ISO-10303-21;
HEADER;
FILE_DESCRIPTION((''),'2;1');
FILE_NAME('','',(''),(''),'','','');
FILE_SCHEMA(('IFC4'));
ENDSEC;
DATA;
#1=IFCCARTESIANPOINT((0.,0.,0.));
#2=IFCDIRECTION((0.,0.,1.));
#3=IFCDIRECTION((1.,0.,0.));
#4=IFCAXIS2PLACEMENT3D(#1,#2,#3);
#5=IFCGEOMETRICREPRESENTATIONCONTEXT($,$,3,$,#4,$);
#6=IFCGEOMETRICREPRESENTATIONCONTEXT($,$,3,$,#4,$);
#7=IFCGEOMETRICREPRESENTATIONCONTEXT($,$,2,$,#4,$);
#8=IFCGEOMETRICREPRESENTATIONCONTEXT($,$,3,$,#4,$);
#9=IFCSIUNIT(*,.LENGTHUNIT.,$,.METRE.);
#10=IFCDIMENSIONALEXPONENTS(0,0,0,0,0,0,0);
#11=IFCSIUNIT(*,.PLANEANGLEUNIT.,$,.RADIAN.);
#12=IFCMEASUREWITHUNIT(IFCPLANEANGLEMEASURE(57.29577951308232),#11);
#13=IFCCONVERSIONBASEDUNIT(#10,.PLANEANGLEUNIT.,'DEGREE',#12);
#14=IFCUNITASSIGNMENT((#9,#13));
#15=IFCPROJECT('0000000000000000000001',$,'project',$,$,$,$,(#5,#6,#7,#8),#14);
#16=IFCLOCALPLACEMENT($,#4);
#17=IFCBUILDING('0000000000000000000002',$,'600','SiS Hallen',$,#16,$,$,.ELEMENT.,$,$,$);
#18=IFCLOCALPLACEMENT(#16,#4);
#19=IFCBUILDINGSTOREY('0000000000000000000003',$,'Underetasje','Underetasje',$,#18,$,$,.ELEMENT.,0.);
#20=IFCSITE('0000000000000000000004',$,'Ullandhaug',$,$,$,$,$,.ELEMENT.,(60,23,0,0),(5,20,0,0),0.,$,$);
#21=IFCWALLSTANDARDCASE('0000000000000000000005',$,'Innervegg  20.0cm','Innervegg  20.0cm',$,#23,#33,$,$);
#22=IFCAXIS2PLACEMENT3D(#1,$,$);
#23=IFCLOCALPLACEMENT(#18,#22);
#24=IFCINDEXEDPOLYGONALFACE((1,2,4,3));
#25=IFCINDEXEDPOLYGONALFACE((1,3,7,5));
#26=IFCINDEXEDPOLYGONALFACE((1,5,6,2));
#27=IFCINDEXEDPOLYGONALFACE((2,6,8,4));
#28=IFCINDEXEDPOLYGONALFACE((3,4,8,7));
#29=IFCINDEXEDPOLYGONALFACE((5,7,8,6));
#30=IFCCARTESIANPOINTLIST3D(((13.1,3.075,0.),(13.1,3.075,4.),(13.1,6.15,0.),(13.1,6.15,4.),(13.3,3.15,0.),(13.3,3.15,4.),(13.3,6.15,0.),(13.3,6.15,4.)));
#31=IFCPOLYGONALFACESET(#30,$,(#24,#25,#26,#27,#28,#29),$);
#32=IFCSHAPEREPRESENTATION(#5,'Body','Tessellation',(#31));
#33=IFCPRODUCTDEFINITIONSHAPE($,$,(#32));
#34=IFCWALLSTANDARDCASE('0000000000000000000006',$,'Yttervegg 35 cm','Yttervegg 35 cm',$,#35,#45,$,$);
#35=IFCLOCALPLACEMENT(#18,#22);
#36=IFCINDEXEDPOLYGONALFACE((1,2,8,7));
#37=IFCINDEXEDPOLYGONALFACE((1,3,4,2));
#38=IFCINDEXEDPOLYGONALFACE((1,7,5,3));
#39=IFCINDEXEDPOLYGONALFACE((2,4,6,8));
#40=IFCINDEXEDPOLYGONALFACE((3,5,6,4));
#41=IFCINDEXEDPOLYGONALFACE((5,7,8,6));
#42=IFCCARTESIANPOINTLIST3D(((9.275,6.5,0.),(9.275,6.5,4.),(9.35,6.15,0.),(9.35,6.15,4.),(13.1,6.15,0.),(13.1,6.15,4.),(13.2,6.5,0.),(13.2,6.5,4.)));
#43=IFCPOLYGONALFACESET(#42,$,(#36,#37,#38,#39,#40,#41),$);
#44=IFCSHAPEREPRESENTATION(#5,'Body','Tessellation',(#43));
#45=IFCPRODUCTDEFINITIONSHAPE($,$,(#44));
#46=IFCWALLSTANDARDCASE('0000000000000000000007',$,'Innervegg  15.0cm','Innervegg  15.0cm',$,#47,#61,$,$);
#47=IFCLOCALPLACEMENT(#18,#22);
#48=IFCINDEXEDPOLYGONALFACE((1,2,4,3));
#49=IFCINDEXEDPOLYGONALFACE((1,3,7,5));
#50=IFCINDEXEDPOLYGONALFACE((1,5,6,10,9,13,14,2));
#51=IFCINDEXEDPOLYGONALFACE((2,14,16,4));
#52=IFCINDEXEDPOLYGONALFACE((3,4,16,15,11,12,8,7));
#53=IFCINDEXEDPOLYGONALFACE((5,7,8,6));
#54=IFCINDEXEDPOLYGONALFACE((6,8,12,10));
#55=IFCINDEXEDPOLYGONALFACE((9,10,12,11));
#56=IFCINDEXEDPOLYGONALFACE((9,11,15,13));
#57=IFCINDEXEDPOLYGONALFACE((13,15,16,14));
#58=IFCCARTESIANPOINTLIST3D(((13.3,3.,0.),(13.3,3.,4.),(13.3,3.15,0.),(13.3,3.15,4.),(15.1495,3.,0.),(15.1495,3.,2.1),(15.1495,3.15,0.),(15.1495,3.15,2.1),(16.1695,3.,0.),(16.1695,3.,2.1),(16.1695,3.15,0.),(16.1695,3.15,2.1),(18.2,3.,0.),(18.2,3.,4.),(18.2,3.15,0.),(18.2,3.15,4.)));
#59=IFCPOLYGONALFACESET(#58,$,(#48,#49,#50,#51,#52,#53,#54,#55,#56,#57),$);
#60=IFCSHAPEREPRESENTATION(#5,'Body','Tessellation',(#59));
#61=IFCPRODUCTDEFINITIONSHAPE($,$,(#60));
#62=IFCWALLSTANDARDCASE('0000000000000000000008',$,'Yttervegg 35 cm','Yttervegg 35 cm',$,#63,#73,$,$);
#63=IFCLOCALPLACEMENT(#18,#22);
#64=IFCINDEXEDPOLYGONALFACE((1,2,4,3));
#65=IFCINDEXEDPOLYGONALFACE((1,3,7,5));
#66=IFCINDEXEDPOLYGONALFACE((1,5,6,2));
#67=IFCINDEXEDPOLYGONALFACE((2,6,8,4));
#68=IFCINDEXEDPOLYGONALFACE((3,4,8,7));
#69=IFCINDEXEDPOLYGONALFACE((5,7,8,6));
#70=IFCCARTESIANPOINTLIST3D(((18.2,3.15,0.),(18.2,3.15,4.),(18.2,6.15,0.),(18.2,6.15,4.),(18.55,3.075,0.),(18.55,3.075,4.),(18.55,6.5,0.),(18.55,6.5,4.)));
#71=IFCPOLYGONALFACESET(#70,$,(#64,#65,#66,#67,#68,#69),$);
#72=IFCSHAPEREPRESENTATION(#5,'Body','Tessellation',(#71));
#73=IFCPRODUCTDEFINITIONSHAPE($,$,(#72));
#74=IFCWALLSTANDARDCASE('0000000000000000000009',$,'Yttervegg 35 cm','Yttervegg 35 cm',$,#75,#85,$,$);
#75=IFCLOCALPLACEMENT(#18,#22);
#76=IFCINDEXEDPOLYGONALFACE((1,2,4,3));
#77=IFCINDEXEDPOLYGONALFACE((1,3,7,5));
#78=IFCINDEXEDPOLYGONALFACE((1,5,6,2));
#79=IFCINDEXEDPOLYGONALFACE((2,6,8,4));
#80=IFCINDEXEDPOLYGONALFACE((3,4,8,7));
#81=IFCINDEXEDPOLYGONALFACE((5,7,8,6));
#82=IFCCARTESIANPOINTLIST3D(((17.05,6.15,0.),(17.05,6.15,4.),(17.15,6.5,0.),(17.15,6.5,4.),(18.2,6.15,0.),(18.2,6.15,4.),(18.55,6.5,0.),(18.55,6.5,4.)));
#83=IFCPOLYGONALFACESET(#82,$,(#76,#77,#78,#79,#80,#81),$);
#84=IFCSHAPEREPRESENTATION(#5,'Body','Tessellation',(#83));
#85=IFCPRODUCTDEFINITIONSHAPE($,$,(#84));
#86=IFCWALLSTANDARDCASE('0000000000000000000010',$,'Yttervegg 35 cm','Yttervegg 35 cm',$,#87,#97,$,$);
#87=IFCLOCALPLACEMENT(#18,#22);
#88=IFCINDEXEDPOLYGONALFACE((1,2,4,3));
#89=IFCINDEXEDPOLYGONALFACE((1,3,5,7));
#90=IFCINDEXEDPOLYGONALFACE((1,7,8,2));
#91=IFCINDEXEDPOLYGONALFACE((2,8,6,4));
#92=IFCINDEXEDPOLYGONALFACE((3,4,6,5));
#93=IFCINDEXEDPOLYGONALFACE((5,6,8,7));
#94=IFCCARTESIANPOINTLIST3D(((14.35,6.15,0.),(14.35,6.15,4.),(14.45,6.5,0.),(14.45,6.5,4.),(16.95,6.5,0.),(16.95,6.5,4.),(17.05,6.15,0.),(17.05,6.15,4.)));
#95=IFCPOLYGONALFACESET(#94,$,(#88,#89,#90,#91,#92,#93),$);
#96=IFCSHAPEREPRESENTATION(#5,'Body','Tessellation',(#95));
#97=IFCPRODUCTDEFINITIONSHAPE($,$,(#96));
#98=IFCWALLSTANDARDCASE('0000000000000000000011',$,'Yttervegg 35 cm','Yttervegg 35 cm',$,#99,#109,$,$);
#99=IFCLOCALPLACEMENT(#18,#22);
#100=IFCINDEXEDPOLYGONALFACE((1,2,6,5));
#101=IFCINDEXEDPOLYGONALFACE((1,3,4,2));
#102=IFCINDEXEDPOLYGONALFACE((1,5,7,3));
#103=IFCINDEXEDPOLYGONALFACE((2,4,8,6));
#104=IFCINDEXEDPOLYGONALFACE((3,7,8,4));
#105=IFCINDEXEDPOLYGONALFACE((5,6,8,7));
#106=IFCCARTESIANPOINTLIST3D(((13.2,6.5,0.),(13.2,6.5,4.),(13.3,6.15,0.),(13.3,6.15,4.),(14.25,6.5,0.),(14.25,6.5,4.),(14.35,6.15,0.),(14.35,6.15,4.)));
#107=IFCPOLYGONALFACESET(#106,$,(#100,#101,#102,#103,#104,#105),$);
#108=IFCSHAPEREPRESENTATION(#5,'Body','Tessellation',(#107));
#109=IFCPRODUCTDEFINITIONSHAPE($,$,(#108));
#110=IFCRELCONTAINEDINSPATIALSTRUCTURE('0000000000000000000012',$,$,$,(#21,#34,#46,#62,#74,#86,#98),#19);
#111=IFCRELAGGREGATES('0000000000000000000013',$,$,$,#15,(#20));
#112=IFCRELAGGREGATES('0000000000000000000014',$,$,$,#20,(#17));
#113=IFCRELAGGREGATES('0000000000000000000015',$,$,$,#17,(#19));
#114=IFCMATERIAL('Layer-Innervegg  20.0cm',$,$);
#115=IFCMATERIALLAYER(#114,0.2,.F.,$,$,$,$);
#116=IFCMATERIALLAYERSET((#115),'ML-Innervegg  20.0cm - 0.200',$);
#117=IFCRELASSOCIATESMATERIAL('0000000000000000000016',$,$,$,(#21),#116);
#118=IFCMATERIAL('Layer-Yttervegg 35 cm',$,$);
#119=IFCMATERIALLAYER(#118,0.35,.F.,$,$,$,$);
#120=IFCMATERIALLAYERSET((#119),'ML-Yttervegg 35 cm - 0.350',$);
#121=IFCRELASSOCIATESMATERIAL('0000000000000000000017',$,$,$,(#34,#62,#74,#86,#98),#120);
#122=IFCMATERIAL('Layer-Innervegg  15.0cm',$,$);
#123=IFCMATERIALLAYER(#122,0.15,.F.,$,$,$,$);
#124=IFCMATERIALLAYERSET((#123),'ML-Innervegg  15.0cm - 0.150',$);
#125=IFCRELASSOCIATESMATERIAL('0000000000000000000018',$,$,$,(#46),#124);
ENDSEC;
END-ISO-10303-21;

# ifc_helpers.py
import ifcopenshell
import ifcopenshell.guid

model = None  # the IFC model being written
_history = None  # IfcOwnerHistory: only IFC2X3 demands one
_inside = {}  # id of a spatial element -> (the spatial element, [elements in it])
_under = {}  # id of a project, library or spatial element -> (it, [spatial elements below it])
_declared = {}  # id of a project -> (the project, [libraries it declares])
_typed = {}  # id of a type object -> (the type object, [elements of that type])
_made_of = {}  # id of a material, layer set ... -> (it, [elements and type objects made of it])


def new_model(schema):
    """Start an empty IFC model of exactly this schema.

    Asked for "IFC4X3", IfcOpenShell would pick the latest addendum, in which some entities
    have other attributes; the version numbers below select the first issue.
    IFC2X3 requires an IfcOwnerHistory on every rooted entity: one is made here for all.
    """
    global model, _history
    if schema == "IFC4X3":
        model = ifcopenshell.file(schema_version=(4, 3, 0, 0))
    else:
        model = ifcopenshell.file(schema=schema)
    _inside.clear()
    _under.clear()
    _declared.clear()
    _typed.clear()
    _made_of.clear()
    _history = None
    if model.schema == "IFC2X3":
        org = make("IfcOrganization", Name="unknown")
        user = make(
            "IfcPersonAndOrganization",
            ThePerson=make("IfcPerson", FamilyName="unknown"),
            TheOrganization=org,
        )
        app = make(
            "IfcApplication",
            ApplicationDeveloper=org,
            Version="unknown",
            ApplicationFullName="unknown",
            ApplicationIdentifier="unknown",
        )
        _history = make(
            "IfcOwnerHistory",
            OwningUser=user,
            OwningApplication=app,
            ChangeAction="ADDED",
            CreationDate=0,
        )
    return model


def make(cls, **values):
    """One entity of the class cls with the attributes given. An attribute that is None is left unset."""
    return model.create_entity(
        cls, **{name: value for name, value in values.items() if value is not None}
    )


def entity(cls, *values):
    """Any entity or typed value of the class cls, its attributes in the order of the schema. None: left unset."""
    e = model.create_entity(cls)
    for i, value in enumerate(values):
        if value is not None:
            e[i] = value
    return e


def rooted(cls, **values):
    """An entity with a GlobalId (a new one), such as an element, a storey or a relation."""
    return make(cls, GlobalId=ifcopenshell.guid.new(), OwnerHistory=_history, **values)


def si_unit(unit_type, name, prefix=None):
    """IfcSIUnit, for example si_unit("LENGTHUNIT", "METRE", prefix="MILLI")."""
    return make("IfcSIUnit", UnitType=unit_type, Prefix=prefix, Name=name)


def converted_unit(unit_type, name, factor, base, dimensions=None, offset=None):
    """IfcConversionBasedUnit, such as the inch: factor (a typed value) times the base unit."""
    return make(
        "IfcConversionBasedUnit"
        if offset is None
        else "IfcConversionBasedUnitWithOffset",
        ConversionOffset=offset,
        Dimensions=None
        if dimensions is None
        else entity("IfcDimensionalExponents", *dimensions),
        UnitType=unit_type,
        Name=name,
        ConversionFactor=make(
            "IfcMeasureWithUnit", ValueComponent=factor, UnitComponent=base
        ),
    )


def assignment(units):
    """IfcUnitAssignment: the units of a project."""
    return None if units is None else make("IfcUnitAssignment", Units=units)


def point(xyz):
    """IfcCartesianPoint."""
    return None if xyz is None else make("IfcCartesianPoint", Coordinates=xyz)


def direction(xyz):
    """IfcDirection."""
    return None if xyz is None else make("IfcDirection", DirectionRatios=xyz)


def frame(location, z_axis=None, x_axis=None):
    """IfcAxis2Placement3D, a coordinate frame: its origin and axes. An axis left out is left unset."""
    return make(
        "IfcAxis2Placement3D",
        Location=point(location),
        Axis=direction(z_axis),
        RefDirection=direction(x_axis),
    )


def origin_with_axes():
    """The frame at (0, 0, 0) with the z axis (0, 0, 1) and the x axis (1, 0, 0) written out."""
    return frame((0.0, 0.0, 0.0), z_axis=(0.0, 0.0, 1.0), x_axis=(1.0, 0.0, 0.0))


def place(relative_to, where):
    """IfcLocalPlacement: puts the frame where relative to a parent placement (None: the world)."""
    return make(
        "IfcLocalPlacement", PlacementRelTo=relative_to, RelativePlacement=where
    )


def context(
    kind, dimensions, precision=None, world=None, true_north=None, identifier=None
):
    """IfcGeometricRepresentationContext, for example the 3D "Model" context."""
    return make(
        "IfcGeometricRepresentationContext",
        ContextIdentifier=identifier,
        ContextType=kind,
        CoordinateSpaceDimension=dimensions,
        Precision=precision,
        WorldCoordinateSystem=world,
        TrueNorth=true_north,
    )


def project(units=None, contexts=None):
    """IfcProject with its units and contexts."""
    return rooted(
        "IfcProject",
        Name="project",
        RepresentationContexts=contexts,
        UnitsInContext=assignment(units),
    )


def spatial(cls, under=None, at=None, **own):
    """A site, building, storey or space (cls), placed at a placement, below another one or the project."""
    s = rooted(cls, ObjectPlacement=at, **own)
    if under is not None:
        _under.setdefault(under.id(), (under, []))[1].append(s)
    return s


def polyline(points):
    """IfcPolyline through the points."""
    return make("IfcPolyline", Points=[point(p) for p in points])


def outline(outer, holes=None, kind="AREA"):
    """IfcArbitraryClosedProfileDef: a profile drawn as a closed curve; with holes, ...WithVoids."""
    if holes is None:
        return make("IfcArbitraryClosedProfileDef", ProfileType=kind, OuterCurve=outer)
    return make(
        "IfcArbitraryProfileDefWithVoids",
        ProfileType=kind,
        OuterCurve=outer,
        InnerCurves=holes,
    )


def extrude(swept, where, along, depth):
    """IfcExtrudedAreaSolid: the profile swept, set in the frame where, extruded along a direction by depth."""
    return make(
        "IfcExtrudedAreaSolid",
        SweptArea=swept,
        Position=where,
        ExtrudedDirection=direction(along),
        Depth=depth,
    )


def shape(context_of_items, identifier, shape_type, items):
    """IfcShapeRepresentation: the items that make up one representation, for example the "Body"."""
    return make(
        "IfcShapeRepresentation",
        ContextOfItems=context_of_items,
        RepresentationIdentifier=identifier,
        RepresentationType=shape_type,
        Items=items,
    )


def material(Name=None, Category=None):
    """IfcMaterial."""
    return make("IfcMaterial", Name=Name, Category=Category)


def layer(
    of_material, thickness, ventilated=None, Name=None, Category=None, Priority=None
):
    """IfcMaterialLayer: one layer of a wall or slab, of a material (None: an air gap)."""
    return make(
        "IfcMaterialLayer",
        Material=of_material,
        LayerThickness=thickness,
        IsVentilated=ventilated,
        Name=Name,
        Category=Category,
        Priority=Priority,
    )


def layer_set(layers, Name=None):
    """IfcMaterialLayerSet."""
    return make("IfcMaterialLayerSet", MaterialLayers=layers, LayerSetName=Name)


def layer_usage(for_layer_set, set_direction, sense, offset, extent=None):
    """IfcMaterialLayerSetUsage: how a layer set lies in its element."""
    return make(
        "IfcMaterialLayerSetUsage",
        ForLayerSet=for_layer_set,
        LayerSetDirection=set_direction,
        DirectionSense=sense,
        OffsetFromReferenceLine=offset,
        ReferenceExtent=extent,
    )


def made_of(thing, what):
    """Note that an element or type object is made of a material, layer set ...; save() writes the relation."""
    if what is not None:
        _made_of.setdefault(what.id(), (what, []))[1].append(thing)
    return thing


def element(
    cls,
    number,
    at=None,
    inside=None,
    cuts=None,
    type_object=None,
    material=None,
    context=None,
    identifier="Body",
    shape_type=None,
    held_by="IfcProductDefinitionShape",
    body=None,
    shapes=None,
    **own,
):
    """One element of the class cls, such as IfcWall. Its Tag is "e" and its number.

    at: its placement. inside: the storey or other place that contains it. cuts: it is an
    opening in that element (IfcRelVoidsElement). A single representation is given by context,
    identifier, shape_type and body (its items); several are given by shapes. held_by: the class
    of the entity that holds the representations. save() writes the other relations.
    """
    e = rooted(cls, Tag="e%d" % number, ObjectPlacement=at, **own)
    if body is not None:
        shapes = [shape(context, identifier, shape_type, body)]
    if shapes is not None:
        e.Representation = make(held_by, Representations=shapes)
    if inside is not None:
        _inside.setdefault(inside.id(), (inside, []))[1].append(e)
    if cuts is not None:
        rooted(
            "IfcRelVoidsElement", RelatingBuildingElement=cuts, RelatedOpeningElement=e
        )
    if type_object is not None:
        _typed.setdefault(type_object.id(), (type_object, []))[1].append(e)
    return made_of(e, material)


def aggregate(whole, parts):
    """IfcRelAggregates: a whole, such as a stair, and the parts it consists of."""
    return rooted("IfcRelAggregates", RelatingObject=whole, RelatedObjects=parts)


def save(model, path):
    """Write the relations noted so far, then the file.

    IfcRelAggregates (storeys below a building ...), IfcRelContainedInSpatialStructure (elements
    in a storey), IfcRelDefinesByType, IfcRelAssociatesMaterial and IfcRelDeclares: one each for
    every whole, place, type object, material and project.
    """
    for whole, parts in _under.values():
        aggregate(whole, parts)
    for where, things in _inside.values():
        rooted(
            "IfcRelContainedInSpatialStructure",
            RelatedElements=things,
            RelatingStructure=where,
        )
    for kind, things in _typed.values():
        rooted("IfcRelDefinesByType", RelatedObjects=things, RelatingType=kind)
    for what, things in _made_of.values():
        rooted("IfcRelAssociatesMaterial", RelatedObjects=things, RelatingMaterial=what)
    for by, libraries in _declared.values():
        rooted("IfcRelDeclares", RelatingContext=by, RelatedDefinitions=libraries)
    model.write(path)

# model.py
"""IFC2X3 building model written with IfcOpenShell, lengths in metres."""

from ifc_helpers import new_model, entity, si_unit, converted_unit, frame, origin_with_axes, place, context, project, spatial, polyline, outline, extrude, material, layer, layer_set, layer_usage, element, save


model = new_model("IFC2X3")

# Units and contexts
context_of_model_1 = context(None, 3, world=origin_with_axes())
context_of_model_2 = context(None, 3, world=origin_with_axes())
context_of_model_3 = context(None, 2, world=origin_with_axes())
context_of_model_4 = context(None, 3, world=origin_with_axes())
ifc_project = project(units=[si_unit("LENGTHUNIT", "METRE"), converted_unit("PLANEANGLEUNIT", "DEGREE", entity("IfcPlaneAngleMeasure", 57.29577951308232), si_unit("PLANEANGLEUNIT", "RADIAN"), dimensions=[0, 0, 0, 0, 0, 0, 0])], contexts=[context_of_model_1, context_of_model_2, context_of_model_3, context_of_model_4])

# Site, building, storey
site = spatial("IfcSite", under=ifc_project, Name="Ullandhaug", CompositionType="ELEMENT", RefLatitude=(60, 23, 0, 0), RefLongitude=(5, 20, 0, 0), RefElevation=0.0)
building_placement = place(None, origin_with_axes())
building = spatial("IfcBuilding", under=site, at=building_placement, Name="600", Description="SiS Hallen", CompositionType="ELEMENT")
storey_placement = place(building_placement, origin_with_axes())
storey = spatial("IfcBuildingStorey", under=building, at=storey_placement, Name="Underetasje", Description="Underetasje", CompositionType="ELEMENT", Elevation=0.0)

# Shared definitions
ifc_material_1 = material(Name="Layer-Innervegg  15.0cm")
ifc_layer_1 = layer(ifc_material_1, 0.15, ventilated=False)
ifc_layer_set_1 = layer_set([ifc_layer_1], Name="ML-Innervegg  15.0cm - 0.150")
ifc_layer_usage_1 = layer_usage(ifc_layer_set_1, "AXIS2", "POSITIVE", 0.0)

# Shared definitions
ifc_material_2 = material(Name="Layer-Yttervegg 35 cm")
ifc_layer_2 = layer(ifc_material_2, 0.35, ventilated=False)
ifc_layer_set_2 = layer_set([ifc_layer_2], Name="ML-Yttervegg 35 cm - 0.350")
ifc_layer_usage_2 = layer_usage(ifc_layer_set_2, "AXIS2", "POSITIVE", 0.0)

# Walls
ifc_material_3 = material(Name="Layer-Innervegg  20.0cm")
ifc_layer_3 = layer(ifc_material_3, 0.2, ventilated=False)
ifc_layer_set_3 = layer_set([ifc_layer_3], Name="ML-Innervegg  20.0cm - 0.200")
ifc_layer_usage_3 = layer_usage(ifc_layer_set_3, "AXIS2", "POSITIVE", 0.0)
wall_1_placement = place(storey_placement, frame((13.3, 3.15, 0.0), z_axis=(0.0, 0.0, 1.0), x_axis=(0.0, 1.0, 0.0)))
element("IfcWallStandardCase", 1, at=wall_1_placement, inside=storey, material=ifc_layer_usage_3, Name="Innervegg  20.0cm", Description="Innervegg  20.0cm", context=context_of_model_1, shape_type="SweptSolid", body=[
    extrude(outline(polyline([(0.0, 0.0), (3.0, 0.0), (3.0, 0.2), (-0.075, 0.2), (0.0, 0.0)])), frame((0.0, 0.0, 0.0), z_axis=(0.0, 0.0, 1.0), x_axis=(1.0, 0.0, 0.0)), (0.0, 0.0, 1.0), 4.0),
])
wall_2_placement = place(storey_placement, frame((13.2, 6.5, 0.0), z_axis=(0.0, 0.0, 1.0), x_axis=(-1.0, 0.0, 0.0)))
element("IfcWallStandardCase", 2, at=wall_2_placement, inside=storey, material=ifc_layer_usage_2, Name="Yttervegg 35 cm", Description="Yttervegg 35 cm", context=context_of_model_1, shape_type="SweptSolid", body=[
    extrude(outline(polyline([(0.0, 0.0), (3.925, 0.0), (3.85, 0.35), (0.1, 0.35), (0.0, 0.0)])), frame((0.0, 0.0, 0.0), z_axis=(0.0, 0.0, 1.0), x_axis=(1.0, 0.0, 0.0)), (0.0, 0.0, 1.0), 4.0),
])

# Wall, opening
wall_3_placement = place(storey_placement, frame((18.2, 3.15, 0.0), z_axis=(0.0, 0.0, 1.0), x_axis=(-1.0, 0.0, 0.0)))
wall_3 = element("IfcWallStandardCase", 3, at=wall_3_placement, inside=storey, material=ifc_layer_usage_1, Name="Innervegg  15.0cm", Description="Innervegg  15.0cm", context=context_of_model_1, shape_type="SweptSolid", body=[
    extrude(outline(polyline([(0.0, 0.0), (4.9, 0.0), (4.9, 0.15), (0.0, 0.15), (0.0, 0.0)])), frame((0.0, 0.0, 0.0), z_axis=(0.0, 0.0, 1.0), x_axis=(1.0, 0.0, 0.0)), (0.0, 0.0, 1.0), 4.0),
])
opening_1_placement = place(wall_3_placement, frame((2.0305, 0.15, 0.0), z_axis=(0.0, 0.0, 1.0), x_axis=(1.0, 0.0, 0.0)))
element("IfcOpeningElement", 4, at=opening_1_placement, cuts=wall_3, context=context_of_model_1, shape_type="SweptSolid", body=[
    extrude(outline(polyline([(0.0, 0.0), (2.1, 0.0), (2.1, 1.02), (0.0, 1.02), (0.0, 0.0)])), frame((0.0, 0.0, 0.0), z_axis=(0.0, 1.0, 0.0), x_axis=(0.0, 0.0, 1.0)), (0.0, 0.0, -1.0), 0.15),
])

# Walls
wall_4_placement = place(storey_placement, frame((18.55, 3.075, 0.0), z_axis=(0.0, 0.0, 1.0), x_axis=(0.0, 1.0, 0.0)))
element("IfcWallStandardCase", 5, at=wall_4_placement, inside=storey, material=ifc_layer_usage_2, Name="Yttervegg 35 cm", Description="Yttervegg 35 cm", context=context_of_model_1, shape_type="SweptSolid", body=[
    extrude(outline(polyline([(0.0, 0.0), (3.425, 0.0), (3.075, 0.35), (0.075, 0.35), (0.0, 0.0)])), frame((0.0, 0.0, 0.0), z_axis=(0.0, 0.0, 1.0), x_axis=(1.0, 0.0, 0.0)), (0.0, 0.0, 1.0), 4.0),
])
wall_5_placement = place(storey_placement, frame((18.55, 6.5, 0.0), z_axis=(0.0, 0.0, 1.0), x_axis=(-1.0, 0.0, 0.0)))
element("IfcWallStandardCase", 6, at=wall_5_placement, inside=storey, material=ifc_layer_usage_2, Name="Yttervegg 35 cm", Description="Yttervegg 35 cm", context=context_of_model_1, shape_type="SweptSolid", body=[
    extrude(outline(polyline([(0.0, 0.0), (1.4, 0.0), (1.5, 0.35), (0.35, 0.35), (0.0, 0.0)])), frame((0.0, 0.0, 0.0), z_axis=(0.0, 0.0, 1.0), x_axis=(1.0, 0.0, 0.0)), (0.0, 0.0, 1.0), 4.0),
])
wall_6_placement = place(storey_placement, frame((16.95, 6.5, 0.0), z_axis=(0.0, 0.0, 1.0), x_axis=(-1.0, 0.0, 0.0)))
element("IfcWallStandardCase", 7, at=wall_6_placement, inside=storey, material=ifc_layer_usage_2, Name="Yttervegg 35 cm", Description="Yttervegg 35 cm", context=context_of_model_1, shape_type="SweptSolid", body=[
    extrude(outline(polyline([(0.0, 0.0), (2.5, 0.0), (2.6, 0.35), (-0.1, 0.35), (0.0, 0.0)])), frame((0.0, 0.0, 0.0), z_axis=(0.0, 0.0, 1.0), x_axis=(1.0, 0.0, 0.0)), (0.0, 0.0, 1.0), 4.0),
])
wall_7_placement = place(storey_placement, frame((14.25, 6.5, 0.0), z_axis=(0.0, 0.0, 1.0), x_axis=(-1.0, 0.0, 0.0)))
element("IfcWallStandardCase", 8, at=wall_7_placement, inside=storey, material=ifc_layer_usage_2, Name="Yttervegg 35 cm", Description="Yttervegg 35 cm", context=context_of_model_1, shape_type="SweptSolid", body=[
    extrude(outline(polyline([(0.0, 0.0), (1.05, 0.0), (0.95, 0.35), (-0.1, 0.35), (0.0, 0.0)])), frame((0.0, 0.0, 0.0), z_axis=(0.0, 0.0, 1.0), x_axis=(1.0, 0.0, 0.0)), (0.0, 0.0, 1.0), 4.0),
])

save(model, "model.ifc")
